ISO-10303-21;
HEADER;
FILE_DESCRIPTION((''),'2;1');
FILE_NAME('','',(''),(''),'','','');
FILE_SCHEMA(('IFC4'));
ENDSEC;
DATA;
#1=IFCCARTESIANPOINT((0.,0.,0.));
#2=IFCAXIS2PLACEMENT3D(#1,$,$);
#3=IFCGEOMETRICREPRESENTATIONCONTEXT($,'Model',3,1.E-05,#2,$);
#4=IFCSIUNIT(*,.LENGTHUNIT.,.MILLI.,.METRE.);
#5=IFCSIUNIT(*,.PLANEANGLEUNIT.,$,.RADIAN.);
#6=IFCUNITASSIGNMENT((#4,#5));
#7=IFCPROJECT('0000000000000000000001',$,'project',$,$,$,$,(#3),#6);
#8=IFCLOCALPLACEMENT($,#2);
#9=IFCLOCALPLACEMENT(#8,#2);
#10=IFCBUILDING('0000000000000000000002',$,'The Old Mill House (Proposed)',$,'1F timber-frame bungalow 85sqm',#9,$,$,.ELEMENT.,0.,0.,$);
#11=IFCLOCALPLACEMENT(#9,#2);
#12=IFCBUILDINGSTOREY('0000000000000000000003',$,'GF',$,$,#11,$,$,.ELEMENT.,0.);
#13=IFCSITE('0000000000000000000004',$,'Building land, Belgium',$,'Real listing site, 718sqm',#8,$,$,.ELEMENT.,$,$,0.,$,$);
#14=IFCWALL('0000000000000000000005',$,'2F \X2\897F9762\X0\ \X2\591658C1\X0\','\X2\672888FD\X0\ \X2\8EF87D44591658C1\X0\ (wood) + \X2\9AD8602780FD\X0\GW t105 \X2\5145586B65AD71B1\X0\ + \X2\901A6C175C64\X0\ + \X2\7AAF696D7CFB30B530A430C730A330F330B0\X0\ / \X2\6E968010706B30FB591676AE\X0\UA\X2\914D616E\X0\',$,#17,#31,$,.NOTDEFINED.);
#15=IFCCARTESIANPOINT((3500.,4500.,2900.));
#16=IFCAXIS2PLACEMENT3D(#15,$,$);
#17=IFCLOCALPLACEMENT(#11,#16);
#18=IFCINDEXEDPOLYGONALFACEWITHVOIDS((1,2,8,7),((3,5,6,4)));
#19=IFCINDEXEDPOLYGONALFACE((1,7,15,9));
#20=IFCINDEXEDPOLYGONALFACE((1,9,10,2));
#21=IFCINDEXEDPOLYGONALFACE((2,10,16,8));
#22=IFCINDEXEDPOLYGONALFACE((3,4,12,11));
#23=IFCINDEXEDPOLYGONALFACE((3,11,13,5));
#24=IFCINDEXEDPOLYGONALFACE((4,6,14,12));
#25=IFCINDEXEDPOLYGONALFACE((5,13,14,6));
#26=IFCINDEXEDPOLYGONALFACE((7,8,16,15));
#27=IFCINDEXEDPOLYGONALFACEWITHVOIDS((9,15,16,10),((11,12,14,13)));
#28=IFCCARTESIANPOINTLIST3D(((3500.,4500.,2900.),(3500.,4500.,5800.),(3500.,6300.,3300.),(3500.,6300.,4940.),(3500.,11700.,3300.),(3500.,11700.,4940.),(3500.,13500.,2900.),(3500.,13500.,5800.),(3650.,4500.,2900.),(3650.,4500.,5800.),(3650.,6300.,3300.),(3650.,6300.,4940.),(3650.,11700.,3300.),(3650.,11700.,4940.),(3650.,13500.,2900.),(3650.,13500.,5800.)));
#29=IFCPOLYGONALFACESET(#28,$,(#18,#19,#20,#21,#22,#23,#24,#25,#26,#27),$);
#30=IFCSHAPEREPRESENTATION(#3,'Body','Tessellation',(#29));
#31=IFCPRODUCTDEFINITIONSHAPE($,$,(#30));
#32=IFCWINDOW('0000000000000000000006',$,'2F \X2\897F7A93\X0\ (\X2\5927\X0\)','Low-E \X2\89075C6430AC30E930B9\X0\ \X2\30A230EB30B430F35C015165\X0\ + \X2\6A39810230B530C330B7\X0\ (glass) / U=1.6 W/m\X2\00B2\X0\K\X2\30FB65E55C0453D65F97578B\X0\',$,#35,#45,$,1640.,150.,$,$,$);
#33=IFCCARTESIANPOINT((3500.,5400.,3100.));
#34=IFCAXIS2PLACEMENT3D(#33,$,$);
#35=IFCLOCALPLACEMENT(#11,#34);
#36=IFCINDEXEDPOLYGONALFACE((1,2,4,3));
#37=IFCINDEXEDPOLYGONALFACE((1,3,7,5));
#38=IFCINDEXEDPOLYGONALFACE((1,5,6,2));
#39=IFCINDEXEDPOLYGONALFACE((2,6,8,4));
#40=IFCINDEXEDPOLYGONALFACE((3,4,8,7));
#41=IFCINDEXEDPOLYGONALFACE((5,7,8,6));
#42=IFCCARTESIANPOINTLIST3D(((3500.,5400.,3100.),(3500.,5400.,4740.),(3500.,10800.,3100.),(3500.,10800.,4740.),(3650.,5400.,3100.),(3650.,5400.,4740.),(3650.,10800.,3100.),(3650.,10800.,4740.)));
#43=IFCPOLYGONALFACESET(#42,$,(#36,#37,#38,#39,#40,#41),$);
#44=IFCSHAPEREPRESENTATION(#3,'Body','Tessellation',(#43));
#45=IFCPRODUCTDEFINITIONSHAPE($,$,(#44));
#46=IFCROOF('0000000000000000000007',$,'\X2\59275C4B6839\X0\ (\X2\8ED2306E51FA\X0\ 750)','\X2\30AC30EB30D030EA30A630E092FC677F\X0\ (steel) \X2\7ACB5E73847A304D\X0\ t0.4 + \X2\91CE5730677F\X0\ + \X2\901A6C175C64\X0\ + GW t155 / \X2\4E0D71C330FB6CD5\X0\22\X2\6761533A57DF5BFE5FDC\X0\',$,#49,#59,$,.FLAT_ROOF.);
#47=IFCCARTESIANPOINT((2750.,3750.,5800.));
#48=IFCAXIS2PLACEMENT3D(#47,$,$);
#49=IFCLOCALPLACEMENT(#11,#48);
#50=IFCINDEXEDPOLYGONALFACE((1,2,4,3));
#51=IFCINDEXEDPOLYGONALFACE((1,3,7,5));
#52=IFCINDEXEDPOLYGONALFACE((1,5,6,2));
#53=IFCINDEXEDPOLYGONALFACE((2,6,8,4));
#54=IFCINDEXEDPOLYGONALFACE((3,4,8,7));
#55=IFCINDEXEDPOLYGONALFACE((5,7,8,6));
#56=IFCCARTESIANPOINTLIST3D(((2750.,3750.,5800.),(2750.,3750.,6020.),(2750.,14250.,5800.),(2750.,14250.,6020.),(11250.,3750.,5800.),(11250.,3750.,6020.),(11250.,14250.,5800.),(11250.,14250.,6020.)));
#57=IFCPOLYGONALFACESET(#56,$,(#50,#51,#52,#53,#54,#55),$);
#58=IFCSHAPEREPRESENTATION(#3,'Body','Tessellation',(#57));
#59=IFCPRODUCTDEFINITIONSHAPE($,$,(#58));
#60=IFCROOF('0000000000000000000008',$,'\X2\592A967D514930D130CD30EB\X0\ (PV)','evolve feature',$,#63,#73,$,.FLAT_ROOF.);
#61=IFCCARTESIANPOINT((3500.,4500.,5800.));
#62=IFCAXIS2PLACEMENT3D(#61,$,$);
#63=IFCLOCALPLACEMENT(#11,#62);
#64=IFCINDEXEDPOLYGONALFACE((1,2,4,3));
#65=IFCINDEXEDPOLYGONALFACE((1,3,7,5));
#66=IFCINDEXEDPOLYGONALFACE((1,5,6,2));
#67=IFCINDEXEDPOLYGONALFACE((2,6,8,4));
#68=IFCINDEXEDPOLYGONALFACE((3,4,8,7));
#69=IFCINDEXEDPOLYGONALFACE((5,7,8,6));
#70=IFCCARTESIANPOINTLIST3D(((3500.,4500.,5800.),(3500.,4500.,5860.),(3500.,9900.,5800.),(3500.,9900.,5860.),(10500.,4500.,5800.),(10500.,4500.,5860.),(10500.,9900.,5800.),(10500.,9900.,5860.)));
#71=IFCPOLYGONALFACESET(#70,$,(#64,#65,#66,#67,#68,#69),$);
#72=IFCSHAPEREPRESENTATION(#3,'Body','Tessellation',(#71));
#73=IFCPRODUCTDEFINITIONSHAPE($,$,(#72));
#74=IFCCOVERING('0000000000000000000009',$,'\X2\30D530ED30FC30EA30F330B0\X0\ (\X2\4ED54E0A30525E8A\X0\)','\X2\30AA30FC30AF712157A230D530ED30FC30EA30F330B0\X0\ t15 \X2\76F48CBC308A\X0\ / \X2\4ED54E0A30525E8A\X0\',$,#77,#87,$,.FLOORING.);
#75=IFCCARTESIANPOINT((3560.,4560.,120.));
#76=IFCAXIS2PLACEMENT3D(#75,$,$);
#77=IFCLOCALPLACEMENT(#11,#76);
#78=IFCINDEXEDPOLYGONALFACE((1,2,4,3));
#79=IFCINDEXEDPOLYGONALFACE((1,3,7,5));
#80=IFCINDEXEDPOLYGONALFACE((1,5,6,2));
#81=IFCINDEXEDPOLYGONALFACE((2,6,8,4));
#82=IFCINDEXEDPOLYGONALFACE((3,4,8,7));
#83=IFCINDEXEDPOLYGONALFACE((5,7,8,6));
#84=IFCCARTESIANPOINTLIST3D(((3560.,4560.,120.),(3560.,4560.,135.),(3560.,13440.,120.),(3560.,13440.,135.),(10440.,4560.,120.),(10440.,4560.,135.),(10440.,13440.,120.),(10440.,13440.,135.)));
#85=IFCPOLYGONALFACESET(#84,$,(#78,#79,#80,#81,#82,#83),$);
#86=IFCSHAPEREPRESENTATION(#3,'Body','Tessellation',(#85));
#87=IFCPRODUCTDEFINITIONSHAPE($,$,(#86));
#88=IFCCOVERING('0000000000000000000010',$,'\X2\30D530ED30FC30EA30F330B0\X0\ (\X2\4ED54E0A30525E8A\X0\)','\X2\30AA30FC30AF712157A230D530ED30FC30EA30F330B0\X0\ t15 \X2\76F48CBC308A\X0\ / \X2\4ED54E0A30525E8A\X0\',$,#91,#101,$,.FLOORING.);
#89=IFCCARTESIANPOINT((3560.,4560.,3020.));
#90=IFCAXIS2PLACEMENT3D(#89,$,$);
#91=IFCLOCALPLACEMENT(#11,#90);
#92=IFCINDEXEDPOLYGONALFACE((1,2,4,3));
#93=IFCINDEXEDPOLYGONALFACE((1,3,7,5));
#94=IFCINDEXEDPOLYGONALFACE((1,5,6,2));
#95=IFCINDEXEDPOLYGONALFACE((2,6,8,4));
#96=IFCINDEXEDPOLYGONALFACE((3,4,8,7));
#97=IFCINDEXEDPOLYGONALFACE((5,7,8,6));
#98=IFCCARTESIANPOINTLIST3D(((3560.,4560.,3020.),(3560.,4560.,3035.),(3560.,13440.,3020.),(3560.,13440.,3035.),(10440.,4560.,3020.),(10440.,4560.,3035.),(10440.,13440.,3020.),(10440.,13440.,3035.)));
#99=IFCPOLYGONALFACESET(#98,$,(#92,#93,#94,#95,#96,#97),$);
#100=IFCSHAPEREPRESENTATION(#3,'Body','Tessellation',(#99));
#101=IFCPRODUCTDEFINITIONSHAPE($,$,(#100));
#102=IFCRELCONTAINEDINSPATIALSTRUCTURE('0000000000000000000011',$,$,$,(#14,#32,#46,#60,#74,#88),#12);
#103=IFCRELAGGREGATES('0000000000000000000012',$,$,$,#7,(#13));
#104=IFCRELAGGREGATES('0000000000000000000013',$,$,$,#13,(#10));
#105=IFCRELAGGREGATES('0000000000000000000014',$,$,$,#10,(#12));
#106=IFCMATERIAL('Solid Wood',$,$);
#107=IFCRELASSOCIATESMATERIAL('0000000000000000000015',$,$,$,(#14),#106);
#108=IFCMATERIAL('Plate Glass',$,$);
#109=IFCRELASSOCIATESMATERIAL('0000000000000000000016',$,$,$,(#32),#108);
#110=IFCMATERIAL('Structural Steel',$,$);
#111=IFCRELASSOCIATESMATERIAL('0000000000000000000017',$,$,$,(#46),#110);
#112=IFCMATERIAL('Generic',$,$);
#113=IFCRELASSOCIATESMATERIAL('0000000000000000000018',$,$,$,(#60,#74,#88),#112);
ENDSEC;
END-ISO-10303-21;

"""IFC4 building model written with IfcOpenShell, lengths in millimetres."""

from ifc_helpers import new_model, si_unit, frame, frame_2d, origin, place, context, project, spatial, rectangle, extrude, material, element, fill, save


model = new_model("IFC4")

# Units and contexts
model_context = context("Model", 3, precision=1e-05, world=origin())
ifc_project = project(units=[si_unit("LENGTHUNIT", "METRE", prefix="MILLI"), si_unit("PLANEANGLEUNIT", "RADIAN")], contexts=[model_context])

# Site, building, storey
site_placement = place(None, origin())
site = spatial("IfcSite", under=ifc_project, at=site_placement, Name="Building land, Belgium", ObjectType="Real listing site, 718sqm", CompositionType="ELEMENT", RefElevation=0.0)
building_placement = place(site_placement, origin())
building = spatial("IfcBuilding", under=site, at=building_placement, Name="The Old Mill House (Proposed)", ObjectType="1F timber-frame bungalow 85sqm", CompositionType="ELEMENT", ElevationOfRefHeight=0.0, ElevationOfTerrain=0.0)
storey_placement = place(building_placement, origin())
storey = spatial("IfcBuildingStorey", under=building, at=storey_placement, Name="GF", CompositionType="ELEMENT", Elevation=0.0)

# Shared definitions
ifc_material_1 = material(Name="Solid Wood")
ifc_material_2 = material(Name="Generic")

# Shared definitions
ifc_material_3 = material(Name="Plate Glass")

# Wall, opening, window
wall_1_placement = place(storey_placement, frame((3500.0, 4500.0, 2900.0)))
wall_1 = element("IfcWall", 1, at=wall_1_placement, inside=storey, material=ifc_material_1, Name="2F 西面 外壁", Description="木製 軸組外壁 (wood) + 高性能GW t105 充填断熱 + 通気層 + 窯業系サイディング / 準耐火・外皮UA配慮", PredefinedType="NOTDEFINED", context=model_context, shape_type="SweptSolid", body=[
    extrude(rectangle(XDim=150.0, YDim=9000.0, at=frame_2d((75.0, 4500.0))), frame((3500.0, 4500.0, 2900.0)), (0.0, 0.0, 1.0), 2900.0),
])
opening_1_placement = place(storey_placement, frame((3500.0, 5400.0, 3100.0)))
opening_1 = element("IfcOpeningElement", 2, at=opening_1_placement, cuts=wall_1, PredefinedType="NOTDEFINED", context=model_context, shape_type="SweptSolid", body=[
    extrude(rectangle(XDim=150.0, YDim=5400.0, at=frame_2d((75.0, 2700.0))), frame((3500.0, 5400.0, 3100.0)), (0.0, 0.0, 1.0), 1640.0),
])
window_1_placement = place(storey_placement, frame((3500.0, 5400.0, 3100.0)))
window_1 = element("IfcWindow", 3, at=window_1_placement, inside=storey, material=ifc_material_3, Name="2F 西窓 (大)", Description="Low-E 複層ガラス アルゴン封入 + 樹脂サッシ (glass) / U=1.6 W/m²K・日射取得型", OverallHeight=1640.0, OverallWidth=150.0, context=model_context, shape_type="SweptSolid", body=[
    extrude(rectangle(XDim=150.0, YDim=5400.0, at=frame_2d((75.0, 2700.0))), frame((3500.0, 5400.0, 3100.0)), (0.0, 0.0, 1.0), 1640.0),
])
fill(opening_1, window_1)

# Roofs
ifc_material_4 = material(Name="Structural Steel")
roof_1_placement = place(storey_placement, frame((2750.0, 3750.0, 5800.0)))
element("IfcRoof", 4, at=roof_1_placement, inside=storey, material=ifc_material_4, Name="大屋根 (軒の出 750)", Description="ガルバリウム鋼板 (steel) 立平葺き t0.4 + 野地板 + 通気層 + GW t155 / 不燃・法22条区域対応", PredefinedType="FLAT_ROOF", context=model_context, shape_type="SweptSolid", body=[
    extrude(rectangle(XDim=8500.0, YDim=10500.0, at=frame_2d((4250.0, 5250.0))), frame((2750.0, 3750.0, 5800.0)), (0.0, 0.0, 1.0), 220.0),
])
roof_2_placement = place(storey_placement, frame((3500.0, 4500.0, 5800.0)))
element("IfcRoof", 5, at=roof_2_placement, inside=storey, material=ifc_material_2, Name="太陽光パネル (PV)", Description="evolve feature", PredefinedType="FLAT_ROOF", context=model_context, shape_type="SweptSolid", body=[
    extrude(rectangle(XDim=7000.0, YDim=5400.0, at=frame_2d((3500.0, 2700.0))), frame((3500.0, 4500.0, 5800.0)), (0.0, 0.0, 1.0), 60.0),
])

# Coverings
covering_1_placement = place(storey_placement, frame((3560.0, 4560.0, 120.0)))
element("IfcCovering", 6, at=covering_1_placement, inside=storey, material=ifc_material_2, Name="フローリング (仕上げ床)", Description="オーク無垢フローリング t15 直貼り / 仕上げ床", PredefinedType="FLOORING", context=model_context, shape_type="SweptSolid", body=[
    extrude(rectangle(XDim=6880.0, YDim=8880.0, at=frame_2d((3440.0, 4440.0))), frame((3560.0, 4560.0, 120.0)), (0.0, 0.0, 1.0), 15.0),
])
covering_2_placement = place(storey_placement, frame((3560.0, 4560.0, 3020.0)))
element("IfcCovering", 7, at=covering_2_placement, inside=storey, material=ifc_material_2, Name="フローリング (仕上げ床)", Description="オーク無垢フローリング t15 直貼り / 仕上げ床", PredefinedType="FLOORING", context=model_context, shape_type="SweptSolid", body=[
    extrude(rectangle(XDim=6880.0, YDim=8880.0, at=frame_2d((3440.0, 4440.0))), frame((3560.0, 4560.0, 3020.0)), (0.0, 0.0, 1.0), 15.0),
])

save(model, "model.ifc")
